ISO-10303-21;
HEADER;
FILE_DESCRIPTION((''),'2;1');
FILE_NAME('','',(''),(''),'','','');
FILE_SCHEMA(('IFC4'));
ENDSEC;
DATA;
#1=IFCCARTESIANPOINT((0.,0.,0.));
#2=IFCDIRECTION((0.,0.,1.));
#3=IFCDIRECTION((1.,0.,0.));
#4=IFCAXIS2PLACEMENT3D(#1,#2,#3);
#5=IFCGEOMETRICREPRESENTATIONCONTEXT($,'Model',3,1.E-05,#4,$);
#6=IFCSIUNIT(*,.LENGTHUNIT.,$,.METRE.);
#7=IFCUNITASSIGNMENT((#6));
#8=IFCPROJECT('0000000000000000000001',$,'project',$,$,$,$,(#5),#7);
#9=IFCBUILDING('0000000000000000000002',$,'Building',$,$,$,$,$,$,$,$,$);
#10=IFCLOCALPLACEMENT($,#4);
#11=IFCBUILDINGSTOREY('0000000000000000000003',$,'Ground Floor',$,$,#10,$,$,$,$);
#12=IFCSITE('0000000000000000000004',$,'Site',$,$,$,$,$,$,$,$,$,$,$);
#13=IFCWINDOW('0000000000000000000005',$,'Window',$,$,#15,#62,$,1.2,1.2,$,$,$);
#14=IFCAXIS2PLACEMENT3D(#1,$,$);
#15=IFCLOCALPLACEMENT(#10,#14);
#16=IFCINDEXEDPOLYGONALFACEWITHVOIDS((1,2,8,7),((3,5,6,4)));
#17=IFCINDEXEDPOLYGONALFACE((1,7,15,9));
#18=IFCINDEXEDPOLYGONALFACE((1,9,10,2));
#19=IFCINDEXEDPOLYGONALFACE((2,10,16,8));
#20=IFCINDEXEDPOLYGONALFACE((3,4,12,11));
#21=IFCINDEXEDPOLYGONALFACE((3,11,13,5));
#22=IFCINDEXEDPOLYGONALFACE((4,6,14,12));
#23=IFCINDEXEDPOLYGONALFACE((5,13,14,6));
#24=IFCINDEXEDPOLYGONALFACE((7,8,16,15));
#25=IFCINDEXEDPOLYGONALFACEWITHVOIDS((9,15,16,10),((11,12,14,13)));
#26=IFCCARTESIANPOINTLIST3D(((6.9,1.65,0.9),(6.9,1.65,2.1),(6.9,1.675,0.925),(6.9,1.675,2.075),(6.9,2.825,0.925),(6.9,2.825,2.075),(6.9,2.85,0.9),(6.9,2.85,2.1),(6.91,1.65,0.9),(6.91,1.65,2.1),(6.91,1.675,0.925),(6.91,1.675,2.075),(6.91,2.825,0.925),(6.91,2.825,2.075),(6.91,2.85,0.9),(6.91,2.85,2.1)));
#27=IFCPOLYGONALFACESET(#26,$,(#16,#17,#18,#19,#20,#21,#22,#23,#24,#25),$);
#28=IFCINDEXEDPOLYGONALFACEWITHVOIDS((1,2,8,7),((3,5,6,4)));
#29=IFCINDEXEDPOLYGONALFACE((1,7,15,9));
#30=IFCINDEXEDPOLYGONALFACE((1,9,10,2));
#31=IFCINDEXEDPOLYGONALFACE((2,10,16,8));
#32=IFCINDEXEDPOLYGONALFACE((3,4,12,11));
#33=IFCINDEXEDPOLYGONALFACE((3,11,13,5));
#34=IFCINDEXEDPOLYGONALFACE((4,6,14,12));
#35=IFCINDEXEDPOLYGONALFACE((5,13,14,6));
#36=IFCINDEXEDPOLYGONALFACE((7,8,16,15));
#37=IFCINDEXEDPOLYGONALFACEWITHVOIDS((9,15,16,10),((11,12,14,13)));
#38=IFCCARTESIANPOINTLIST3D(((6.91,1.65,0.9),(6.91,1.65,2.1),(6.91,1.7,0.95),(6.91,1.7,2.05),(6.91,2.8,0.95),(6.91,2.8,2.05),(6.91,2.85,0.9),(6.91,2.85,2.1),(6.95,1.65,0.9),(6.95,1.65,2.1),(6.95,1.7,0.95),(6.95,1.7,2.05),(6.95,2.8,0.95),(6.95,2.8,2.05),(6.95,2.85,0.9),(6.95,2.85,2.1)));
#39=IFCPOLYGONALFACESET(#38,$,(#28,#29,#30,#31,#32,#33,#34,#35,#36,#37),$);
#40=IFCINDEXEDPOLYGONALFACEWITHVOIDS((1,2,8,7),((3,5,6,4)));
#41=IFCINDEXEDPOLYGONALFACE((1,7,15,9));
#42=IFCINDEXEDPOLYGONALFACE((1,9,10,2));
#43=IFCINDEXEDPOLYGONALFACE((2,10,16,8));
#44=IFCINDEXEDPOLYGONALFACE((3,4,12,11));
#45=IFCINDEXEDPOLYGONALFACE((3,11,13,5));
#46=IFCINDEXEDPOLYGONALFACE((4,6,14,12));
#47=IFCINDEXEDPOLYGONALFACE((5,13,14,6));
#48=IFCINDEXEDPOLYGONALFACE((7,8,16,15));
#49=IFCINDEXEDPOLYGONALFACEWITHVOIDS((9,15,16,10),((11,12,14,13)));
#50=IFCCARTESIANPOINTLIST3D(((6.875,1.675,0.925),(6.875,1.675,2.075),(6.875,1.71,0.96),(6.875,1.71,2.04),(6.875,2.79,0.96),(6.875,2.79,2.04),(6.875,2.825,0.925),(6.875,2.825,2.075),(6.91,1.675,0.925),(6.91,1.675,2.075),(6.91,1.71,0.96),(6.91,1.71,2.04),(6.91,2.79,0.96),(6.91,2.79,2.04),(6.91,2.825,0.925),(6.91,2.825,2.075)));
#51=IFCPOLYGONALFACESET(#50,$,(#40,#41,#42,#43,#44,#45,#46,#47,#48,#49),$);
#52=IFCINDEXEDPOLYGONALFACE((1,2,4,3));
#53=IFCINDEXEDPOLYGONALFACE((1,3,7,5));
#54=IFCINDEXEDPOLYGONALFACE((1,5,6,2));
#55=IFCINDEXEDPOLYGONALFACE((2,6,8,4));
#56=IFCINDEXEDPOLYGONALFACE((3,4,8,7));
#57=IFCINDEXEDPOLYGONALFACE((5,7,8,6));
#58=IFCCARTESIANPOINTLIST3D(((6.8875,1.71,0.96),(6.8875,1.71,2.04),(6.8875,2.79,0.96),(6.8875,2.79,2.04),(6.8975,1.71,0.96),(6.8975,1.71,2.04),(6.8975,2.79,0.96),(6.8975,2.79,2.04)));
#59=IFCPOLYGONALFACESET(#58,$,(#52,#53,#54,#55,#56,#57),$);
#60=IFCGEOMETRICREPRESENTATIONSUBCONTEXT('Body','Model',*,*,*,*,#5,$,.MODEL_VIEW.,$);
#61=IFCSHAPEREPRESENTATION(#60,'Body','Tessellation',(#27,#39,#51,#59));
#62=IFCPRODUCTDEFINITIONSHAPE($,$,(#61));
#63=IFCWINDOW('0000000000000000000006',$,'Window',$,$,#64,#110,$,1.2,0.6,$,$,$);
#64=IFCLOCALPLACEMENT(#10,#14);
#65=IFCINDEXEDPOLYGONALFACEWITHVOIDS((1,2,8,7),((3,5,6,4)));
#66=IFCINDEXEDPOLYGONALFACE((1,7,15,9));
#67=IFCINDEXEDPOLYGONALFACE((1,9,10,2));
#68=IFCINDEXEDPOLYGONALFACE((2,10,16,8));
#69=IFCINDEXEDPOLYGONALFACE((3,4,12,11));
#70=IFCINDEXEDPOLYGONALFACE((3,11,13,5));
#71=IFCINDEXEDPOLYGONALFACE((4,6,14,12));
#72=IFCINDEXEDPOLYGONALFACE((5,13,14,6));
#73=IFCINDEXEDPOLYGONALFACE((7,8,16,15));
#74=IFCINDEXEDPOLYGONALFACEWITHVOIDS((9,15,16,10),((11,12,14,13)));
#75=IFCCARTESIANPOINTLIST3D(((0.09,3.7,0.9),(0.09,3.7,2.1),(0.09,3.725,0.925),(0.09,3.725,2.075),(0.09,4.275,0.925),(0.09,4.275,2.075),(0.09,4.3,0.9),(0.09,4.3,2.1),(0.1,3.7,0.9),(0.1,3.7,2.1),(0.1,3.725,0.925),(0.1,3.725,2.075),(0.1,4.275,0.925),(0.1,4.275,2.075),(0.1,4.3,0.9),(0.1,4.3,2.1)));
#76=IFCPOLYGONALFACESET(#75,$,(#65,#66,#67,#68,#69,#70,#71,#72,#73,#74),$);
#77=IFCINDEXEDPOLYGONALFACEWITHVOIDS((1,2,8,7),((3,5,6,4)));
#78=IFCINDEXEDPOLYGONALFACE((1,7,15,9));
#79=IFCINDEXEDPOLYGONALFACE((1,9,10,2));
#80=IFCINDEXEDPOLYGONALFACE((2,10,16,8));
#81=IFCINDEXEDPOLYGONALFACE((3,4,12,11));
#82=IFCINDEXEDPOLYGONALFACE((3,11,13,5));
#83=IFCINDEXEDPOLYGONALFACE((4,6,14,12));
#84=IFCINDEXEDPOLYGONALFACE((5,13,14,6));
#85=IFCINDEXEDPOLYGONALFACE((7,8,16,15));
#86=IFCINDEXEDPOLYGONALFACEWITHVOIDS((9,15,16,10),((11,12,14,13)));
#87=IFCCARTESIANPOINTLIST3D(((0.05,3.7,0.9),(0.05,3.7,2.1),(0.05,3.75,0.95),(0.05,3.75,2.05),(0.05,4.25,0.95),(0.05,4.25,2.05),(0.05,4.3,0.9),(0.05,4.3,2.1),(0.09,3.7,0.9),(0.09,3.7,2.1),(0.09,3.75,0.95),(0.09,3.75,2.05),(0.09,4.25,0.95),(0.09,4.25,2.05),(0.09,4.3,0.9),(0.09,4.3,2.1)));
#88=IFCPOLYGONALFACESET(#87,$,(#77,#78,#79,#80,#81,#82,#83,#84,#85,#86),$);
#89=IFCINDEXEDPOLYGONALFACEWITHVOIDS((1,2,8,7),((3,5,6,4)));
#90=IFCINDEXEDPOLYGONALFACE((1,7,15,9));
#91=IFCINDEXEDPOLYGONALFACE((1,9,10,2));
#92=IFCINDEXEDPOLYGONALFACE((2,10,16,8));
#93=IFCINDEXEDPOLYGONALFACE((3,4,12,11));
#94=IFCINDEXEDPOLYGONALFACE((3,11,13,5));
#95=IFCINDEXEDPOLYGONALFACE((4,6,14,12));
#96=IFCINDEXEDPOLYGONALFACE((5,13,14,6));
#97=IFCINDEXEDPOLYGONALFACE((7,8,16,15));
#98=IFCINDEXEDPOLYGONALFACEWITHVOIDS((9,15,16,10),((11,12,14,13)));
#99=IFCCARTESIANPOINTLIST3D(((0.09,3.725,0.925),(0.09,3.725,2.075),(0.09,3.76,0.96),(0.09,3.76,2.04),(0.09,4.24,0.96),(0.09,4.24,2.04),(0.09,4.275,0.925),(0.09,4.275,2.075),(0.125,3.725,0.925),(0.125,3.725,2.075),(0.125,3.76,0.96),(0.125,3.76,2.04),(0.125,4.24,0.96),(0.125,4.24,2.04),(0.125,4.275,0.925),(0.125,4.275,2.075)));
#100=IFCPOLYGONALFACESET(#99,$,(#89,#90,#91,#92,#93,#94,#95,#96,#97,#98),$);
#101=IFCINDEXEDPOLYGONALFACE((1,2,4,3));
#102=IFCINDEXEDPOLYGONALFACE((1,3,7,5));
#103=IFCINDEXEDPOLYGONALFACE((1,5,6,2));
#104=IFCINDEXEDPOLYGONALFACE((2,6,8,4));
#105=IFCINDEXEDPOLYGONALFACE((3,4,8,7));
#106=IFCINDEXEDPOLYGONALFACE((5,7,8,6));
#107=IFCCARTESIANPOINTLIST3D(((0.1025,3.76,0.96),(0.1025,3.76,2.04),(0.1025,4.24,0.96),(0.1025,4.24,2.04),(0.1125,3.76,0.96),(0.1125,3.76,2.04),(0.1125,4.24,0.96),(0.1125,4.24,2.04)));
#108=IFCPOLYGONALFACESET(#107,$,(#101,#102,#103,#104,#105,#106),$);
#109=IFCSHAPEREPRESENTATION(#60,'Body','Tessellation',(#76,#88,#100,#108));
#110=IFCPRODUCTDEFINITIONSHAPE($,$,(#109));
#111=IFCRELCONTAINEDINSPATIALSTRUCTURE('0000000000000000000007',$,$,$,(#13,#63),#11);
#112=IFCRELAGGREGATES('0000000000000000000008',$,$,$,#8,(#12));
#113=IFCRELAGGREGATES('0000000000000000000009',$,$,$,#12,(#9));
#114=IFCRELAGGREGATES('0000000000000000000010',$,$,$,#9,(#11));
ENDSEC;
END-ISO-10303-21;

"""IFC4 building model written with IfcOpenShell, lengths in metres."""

from ifc_helpers import new_model, si_unit, frame, origin_with_axes, place, context, subcontext, project, spatial, line, indexed_curve, outline, extrude, element, save


model = new_model("IFC4")

# Units and contexts
model_context = context("Model", 3, precision=1e-05, world=origin_with_axes())
body_context = subcontext(model_context, "Body", "Model", "MODEL_VIEW")
ifc_project = project(units=[si_unit("LENGTHUNIT", "METRE")], contexts=[model_context])

# Site, building, storey
site = spatial("IfcSite", under=ifc_project, Name="Site")
building = spatial("IfcBuilding", under=site, Name="Building")
storey_placement = place(None, origin_with_axes())
storey = spatial("IfcBuildingStorey", under=building, at=storey_placement, Name="Ground Floor")

# Windows
window_1_placement = place(storey_placement, frame((7.0, 1.65, 0.9), z_axis=(0.0, 0.0, 1.0), x_axis=(0.0, 1.0, 0.0)))
element("IfcWindow", 1, at=window_1_placement, inside=storey, Name="Window", OverallHeight=1.2, OverallWidth=1.2, context=body_context, shape_type="SweptSolid", body=[
    extrude(outline(indexed_curve([(0.0, 0.0), (1.2, 0.0), (1.2, 1.2), (0.0, 1.2)], segments=[line(1, 2, 3, 4, 1)]), holes=[indexed_curve([(0.025, 0.025), (1.175, 0.025), (1.175, 1.175), (0.025, 1.175)], segments=[line(1, 2, 3, 4, 1)])]), frame((0.0, 0.09, 0.0), z_axis=(0.0, -1.0, 0.0), x_axis=(1.0, 0.0, 0.0)), (0.0, 0.0, -1.0), 0.01),
    extrude(outline(indexed_curve([(0.0, 0.0), (1.2, 0.0), (1.2, 1.2), (0.0, 1.2)], segments=[line(1, 2, 3, 4, 1)]), holes=[indexed_curve([(0.05, 0.05), (1.15, 0.05), (1.15, 1.15), (0.05, 1.15)], segments=[line(1, 2, 3, 4, 1)])]), frame((0.0, 0.05, 0.0), z_axis=(0.0, -1.0, 0.0), x_axis=(1.0, 0.0, 0.0)), (0.0, 0.0, -1.0), 0.04),
    extrude(outline(indexed_curve([(0.0, 0.0), (1.15, 0.0), (1.15, 1.15), (0.0, 1.15)], segments=[line(1, 2, 3, 4, 1)]), holes=[indexed_curve([(0.035, 0.035), (1.115, 0.035), (1.115, 1.115), (0.035, 1.115)], segments=[line(1, 2, 3, 4, 1)])]), frame((0.025, 0.09, 0.025), z_axis=(0.0, -1.0, 0.0), x_axis=(1.0, 0.0, 0.0)), (0.0, 0.0, -1.0), 0.035),
    extrude(outline(indexed_curve([(0.035, 0.035), (1.115, 0.035), (1.115, 1.115), (0.035, 1.115)], segments=[line(1, 2, 3, 4, 1)])), frame((0.025, 0.1025, 0.025), z_axis=(0.0, -1.0, 0.0), x_axis=(1.0, 0.0, 0.0)), (0.0, 0.0, -1.0), 0.01),
])
window_2_placement = place(storey_placement, frame((0.0, 4.3, 0.9), z_axis=(0.0, 0.0, 1.0), x_axis=(0.0, -1.0, 0.0)))
element("IfcWindow", 2, at=window_2_placement, inside=storey, Name="Window", OverallHeight=1.2, OverallWidth=0.6, context=body_context, shape_type="SweptSolid", body=[
    extrude(outline(indexed_curve([(0.0, 0.0), (0.6, 0.0), (0.6, 1.2), (0.0, 1.2)], segments=[line(1, 2, 3, 4, 1)]), holes=[indexed_curve([(0.025, 0.025), (0.575, 0.025), (0.575, 1.175), (0.025, 1.175)], segments=[line(1, 2, 3, 4, 1)])]), frame((0.0, 0.09, 0.0), z_axis=(0.0, -1.0, 0.0), x_axis=(1.0, 0.0, 0.0)), (0.0, 0.0, -1.0), 0.01),
    extrude(outline(indexed_curve([(0.0, 0.0), (0.6, 0.0), (0.6, 1.2), (0.0, 1.2)], segments=[line(1, 2, 3, 4, 1)]), holes=[indexed_curve([(0.05, 0.05), (0.55, 0.05), (0.55, 1.15), (0.05, 1.15)], segments=[line(1, 2, 3, 4, 1)])]), frame((0.0, 0.05, 0.0), z_axis=(0.0, -1.0, 0.0), x_axis=(1.0, 0.0, 0.0)), (0.0, 0.0, -1.0), 0.04),
    extrude(outline(indexed_curve([(0.0, 0.0), (0.55, 0.0), (0.55, 1.15), (0.0, 1.15)], segments=[line(1, 2, 3, 4, 1)]), holes=[indexed_curve([(0.035, 0.035), (0.515, 0.035), (0.515, 1.115), (0.035, 1.115)], segments=[line(1, 2, 3, 4, 1)])]), frame((0.025, 0.09, 0.025), z_axis=(0.0, -1.0, 0.0), x_axis=(1.0, 0.0, 0.0)), (0.0, 0.0, -1.0), 0.035),
    extrude(outline(indexed_curve([(0.035, 0.035), (0.515, 0.035), (0.515, 1.115), (0.035, 1.115)], segments=[line(1, 2, 3, 4, 1)])), frame((0.025, 0.1025, 0.025), z_axis=(0.0, -1.0, 0.0), x_axis=(1.0, 0.0, 0.0)), (0.0, 0.0, -1.0), 0.01),
])

save(model, "model.ifc")
